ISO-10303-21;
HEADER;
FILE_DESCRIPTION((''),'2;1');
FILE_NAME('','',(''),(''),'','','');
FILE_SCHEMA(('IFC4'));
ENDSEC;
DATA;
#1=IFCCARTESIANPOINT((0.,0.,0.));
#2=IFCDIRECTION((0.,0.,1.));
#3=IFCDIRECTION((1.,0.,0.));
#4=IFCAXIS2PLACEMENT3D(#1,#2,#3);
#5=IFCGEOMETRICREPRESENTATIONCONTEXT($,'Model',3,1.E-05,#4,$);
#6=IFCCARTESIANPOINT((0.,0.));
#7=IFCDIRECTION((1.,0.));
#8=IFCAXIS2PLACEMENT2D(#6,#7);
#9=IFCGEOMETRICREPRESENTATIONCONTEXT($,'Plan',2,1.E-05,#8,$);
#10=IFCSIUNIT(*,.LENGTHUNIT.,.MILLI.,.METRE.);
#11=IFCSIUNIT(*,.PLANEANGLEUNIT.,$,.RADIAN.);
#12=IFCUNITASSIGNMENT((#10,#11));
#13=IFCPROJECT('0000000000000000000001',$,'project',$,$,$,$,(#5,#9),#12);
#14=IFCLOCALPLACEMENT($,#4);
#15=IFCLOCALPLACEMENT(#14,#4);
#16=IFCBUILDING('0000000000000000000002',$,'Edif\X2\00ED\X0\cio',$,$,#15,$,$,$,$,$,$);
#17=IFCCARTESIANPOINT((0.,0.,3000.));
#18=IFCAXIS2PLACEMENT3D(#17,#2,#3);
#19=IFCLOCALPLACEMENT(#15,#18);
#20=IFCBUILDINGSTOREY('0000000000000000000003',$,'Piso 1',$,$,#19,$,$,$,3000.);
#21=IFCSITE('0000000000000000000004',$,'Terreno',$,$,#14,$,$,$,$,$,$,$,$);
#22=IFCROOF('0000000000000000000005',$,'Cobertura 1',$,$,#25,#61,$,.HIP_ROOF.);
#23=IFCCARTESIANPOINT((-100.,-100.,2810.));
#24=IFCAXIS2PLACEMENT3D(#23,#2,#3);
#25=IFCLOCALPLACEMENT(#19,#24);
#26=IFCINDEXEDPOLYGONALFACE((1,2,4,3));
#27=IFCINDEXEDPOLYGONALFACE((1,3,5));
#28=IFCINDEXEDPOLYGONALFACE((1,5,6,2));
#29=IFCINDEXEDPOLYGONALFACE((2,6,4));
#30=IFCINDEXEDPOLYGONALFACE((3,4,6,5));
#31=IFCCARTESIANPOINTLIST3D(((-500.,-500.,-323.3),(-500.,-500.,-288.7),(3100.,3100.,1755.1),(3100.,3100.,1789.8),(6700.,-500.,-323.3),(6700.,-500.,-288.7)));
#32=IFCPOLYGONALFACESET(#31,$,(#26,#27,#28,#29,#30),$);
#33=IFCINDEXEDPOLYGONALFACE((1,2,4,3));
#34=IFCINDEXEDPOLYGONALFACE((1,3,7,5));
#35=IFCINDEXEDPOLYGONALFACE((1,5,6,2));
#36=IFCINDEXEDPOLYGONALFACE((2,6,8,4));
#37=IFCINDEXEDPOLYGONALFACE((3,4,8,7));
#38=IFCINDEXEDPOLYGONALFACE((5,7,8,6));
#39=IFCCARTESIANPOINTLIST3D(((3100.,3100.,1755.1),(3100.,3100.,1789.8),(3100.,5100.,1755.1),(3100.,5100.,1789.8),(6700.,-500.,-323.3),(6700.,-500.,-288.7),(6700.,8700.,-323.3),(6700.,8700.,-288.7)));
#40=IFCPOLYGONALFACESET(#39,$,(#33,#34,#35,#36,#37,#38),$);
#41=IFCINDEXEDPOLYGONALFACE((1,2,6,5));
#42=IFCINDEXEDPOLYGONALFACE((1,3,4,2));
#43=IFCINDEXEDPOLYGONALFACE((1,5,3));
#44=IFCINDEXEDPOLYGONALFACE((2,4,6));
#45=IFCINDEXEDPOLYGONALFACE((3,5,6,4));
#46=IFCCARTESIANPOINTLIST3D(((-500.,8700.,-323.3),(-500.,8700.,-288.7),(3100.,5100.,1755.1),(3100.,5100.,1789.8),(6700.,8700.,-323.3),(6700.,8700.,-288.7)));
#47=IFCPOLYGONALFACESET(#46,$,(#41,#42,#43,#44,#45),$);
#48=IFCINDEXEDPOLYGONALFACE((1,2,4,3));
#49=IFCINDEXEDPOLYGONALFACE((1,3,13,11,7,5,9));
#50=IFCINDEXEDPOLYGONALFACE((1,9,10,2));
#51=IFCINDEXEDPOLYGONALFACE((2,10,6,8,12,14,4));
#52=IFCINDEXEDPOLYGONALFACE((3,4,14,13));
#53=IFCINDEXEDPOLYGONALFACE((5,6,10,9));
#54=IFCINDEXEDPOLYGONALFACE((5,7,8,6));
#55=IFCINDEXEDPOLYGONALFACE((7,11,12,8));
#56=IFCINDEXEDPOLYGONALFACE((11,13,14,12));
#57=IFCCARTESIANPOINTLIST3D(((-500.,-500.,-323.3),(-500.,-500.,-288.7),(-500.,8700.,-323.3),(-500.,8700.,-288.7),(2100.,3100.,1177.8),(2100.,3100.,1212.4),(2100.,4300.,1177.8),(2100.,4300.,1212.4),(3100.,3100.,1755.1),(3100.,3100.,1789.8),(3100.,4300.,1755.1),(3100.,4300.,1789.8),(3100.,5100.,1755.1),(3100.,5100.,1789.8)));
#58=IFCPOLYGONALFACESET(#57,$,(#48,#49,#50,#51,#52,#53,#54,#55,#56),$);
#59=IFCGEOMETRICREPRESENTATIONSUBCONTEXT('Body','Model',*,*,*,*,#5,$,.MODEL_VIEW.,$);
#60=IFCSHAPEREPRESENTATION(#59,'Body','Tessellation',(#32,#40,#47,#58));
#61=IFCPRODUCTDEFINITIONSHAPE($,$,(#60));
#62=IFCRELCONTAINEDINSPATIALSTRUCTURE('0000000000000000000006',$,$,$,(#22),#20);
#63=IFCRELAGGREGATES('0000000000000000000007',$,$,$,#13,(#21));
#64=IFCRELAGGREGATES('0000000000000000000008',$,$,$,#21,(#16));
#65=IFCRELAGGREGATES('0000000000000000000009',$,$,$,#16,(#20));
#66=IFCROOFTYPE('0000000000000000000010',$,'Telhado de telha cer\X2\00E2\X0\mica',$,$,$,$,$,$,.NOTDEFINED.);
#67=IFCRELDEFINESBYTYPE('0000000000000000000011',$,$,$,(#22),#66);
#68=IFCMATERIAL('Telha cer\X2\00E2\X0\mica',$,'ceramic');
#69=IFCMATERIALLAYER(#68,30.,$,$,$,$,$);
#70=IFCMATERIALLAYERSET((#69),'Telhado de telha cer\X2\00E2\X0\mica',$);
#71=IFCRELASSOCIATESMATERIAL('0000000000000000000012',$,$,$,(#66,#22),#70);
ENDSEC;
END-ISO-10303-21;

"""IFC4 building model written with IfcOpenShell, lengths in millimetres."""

from ifc_helpers import new_model, si_unit, frame, origin_with_axes, origin_2d_with_axis, place, context, subcontext, project, spatial, indexed_curve, outline, extrude, material, layer, layer_set, type_object, element, save


model = new_model("IFC4")

# Units and contexts
model_context = context("Model", 3, precision=1e-05, world=origin_with_axes())
plan_context = context("Plan", 2, precision=1e-05, world=origin_2d_with_axis())
body_context = subcontext(model_context, "Body", "Model", "MODEL_VIEW")
ifc_project = project(units=[si_unit("LENGTHUNIT", "METRE", prefix="MILLI"), si_unit("PLANEANGLEUNIT", "RADIAN")], contexts=[model_context, plan_context])

# Site, building, storey
site_placement = place(None, origin_with_axes())
site = spatial("IfcSite", under=ifc_project, at=site_placement, Name="Terreno")
building_placement = place(site_placement, origin_with_axes())
building = spatial("IfcBuilding", under=site, at=building_placement, Name="Edifício")
storey_placement = place(building_placement, frame((0.0, 0.0, 3000.0), z_axis=(0.0, 0.0, 1.0), x_axis=(1.0, 0.0, 0.0)))
storey = spatial("IfcBuildingStorey", under=building, at=storey_placement, Name="Piso 1", Elevation=3000.0)

# Roof, opening
ifc_material_1 = material(Name="Telha cerâmica", Category="ceramic")
ifc_layer_1 = layer(ifc_material_1, 30.0)
ifc_layer_set_1 = layer_set([ifc_layer_1], Name="Telhado de telha cerâmica")
roof_type = type_object("IfcRoofType", Name="Telhado de telha cerâmica", PredefinedType="NOTDEFINED", material=ifc_layer_set_1)
roof_1_placement = place(storey_placement, frame((-100.0, -100.0, 2810.0), z_axis=(0.0, 0.0, 1.0), x_axis=(1.0, 0.0, 0.0)))
roof_1 = element("IfcRoof", 1, at=roof_1_placement, inside=storey, type_object=roof_type, material=ifc_layer_set_1, Name="Cobertura 1", PredefinedType="HIP_ROOF", context=body_context, shape_type="SweptSolid", body=[
    extrude(outline(indexed_curve([(3600.0, 4156.9), (0.0, 0.0), (7200.0, 0.0), (3600.0, 4156.9)], self_intersect=False)), frame((-500.0, -500.0, -288.7), z_axis=(0.0, -0.5, 0.866025), x_axis=(1.0, 0.0, 0.0)), (0.0, -0.5, -0.866025), 34.6),
    extrude(outline(indexed_curve([(0.0, 0.0), (9200.0, 0.0), (5600.0, 4156.9), (3600.0, 4156.9), (0.0, 0.0)], self_intersect=False)), frame((6700.0, -500.0, -288.7), z_axis=(0.5, 0.0, 0.866025), x_axis=(0.0, 1.0, 0.0)), (0.0, -0.5, -0.866025), 34.6),
    extrude(outline(indexed_curve([(3600.0, 4156.9), (0.0, 0.0), (7200.0, 0.0), (3600.0, 4156.9)], self_intersect=False)), frame((6700.0, 8700.0, -288.7), z_axis=(0.0, 0.5, 0.866025), x_axis=(-1.0, 0.0, 0.0)), (0.0, -0.5, -0.866025), 34.6),
    extrude(outline(indexed_curve([(5600.0, 4156.9), (3600.0, 4156.9), (0.0, 0.0), (9200.0, 0.0), (5600.0, 4156.9)], self_intersect=False)), frame((-500.0, 8700.0, -288.7), z_axis=(-0.5, 0.0, 0.866025), x_axis=(0.0, -1.0, 0.0)), (0.0, -0.5, -0.866025), 34.6),
])
opening_1_placement = place(roof_1_placement, frame((2100.0, 3100.0, -373.3), z_axis=(0.0, 0.0, 1.0), x_axis=(1.0, 0.0, 0.0)))
element("IfcOpeningElement", 2, at=opening_1_placement, cuts=roof_1, PredefinedType="OPENING", context=body_context, shape_type="SweptSolid", body=[
    extrude(outline(indexed_curve([(0.0, 0.0), (0.0, 1200.0), (1000.0, 1200.0), (1000.0, 0.0), (0.0, 0.0)], self_intersect=False)), origin_with_axes(), (0.0, 0.0, 1.0), 2213.1),
])

save(model, "model.ifc")
